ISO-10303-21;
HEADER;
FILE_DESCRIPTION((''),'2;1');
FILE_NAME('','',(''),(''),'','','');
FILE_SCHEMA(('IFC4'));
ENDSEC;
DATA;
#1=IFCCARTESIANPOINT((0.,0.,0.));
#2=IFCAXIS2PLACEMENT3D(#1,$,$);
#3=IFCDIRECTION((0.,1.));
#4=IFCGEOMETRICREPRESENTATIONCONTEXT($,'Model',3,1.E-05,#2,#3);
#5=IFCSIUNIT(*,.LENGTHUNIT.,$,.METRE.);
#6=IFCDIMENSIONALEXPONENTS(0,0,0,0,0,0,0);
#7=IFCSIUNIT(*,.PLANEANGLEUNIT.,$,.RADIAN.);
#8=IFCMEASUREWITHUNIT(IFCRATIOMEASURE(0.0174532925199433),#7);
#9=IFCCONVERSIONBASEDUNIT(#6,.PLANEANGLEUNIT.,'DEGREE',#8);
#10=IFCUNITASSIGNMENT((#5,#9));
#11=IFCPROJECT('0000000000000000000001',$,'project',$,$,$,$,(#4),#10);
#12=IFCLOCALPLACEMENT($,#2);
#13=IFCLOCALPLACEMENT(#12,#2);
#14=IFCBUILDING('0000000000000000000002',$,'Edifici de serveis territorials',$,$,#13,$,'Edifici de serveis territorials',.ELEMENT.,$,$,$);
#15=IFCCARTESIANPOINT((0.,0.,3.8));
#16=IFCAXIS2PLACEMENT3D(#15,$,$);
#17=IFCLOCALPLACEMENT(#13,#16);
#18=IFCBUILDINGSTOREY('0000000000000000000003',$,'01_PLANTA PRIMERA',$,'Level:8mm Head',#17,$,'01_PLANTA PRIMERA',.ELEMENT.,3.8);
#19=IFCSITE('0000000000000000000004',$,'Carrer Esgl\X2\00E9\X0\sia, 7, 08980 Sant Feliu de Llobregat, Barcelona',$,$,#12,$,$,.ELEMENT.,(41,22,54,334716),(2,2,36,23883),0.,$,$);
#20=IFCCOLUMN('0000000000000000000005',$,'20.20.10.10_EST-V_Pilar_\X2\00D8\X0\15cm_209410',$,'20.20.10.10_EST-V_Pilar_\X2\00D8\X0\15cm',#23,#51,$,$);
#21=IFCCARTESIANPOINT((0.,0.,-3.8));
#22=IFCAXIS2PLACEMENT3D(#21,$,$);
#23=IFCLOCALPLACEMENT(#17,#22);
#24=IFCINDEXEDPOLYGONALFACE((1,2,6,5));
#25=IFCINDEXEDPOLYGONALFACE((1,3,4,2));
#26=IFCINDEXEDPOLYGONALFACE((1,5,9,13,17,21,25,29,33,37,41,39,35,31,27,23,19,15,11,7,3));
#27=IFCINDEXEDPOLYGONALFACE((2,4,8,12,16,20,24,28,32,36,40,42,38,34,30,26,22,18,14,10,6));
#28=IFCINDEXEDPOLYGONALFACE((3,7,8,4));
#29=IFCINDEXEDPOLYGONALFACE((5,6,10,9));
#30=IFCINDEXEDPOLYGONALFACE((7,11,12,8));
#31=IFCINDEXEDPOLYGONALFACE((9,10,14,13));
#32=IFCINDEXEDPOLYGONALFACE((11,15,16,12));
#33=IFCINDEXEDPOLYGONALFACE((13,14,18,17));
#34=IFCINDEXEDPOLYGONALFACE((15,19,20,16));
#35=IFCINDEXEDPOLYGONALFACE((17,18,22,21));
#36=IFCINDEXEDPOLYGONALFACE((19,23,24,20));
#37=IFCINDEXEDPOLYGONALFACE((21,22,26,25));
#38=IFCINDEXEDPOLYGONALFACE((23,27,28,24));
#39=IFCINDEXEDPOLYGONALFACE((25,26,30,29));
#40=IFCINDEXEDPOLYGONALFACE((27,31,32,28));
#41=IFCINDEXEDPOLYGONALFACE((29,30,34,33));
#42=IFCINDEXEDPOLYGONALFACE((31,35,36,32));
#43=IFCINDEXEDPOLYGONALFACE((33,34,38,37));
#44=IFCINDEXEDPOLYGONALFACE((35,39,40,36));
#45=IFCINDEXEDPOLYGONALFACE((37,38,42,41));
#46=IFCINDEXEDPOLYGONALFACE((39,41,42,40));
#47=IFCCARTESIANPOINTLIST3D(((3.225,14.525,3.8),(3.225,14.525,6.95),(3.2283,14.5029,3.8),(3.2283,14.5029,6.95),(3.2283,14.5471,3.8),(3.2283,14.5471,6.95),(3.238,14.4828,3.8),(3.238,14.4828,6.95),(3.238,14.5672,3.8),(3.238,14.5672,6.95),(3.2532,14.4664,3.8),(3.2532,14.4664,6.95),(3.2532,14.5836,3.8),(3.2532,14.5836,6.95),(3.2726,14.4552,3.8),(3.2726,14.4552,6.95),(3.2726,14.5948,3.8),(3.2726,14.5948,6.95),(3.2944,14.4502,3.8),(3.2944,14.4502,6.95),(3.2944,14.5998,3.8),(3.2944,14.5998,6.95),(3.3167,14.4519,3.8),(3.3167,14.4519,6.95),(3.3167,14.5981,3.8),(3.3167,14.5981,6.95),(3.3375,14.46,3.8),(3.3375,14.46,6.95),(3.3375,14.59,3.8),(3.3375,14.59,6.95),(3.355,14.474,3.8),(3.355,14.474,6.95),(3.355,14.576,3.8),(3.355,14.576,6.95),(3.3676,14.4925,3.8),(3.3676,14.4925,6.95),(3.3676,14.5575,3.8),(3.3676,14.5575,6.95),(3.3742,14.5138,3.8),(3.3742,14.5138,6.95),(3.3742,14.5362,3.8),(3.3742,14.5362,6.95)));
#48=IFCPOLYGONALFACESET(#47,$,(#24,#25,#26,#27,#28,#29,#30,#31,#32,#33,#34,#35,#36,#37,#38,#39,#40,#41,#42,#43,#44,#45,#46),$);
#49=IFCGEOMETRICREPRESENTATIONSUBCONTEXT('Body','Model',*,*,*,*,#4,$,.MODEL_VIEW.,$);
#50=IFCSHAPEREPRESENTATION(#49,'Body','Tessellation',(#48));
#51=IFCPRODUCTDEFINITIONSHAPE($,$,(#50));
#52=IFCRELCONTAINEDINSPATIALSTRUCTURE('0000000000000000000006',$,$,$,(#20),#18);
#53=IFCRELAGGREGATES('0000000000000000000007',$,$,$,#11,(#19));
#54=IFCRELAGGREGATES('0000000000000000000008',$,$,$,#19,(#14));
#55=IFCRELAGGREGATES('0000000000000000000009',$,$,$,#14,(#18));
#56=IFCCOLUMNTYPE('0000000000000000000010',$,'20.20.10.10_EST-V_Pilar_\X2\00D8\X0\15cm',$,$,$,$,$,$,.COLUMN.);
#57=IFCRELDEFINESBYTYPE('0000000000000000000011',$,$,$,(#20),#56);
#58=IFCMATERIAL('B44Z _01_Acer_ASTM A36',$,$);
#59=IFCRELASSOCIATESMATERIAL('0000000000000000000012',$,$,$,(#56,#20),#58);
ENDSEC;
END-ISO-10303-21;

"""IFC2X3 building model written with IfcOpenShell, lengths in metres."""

from ifc_helpers import new_model, entity, si_unit, converted_unit, direction, frame, origin, origin_2d_with_axis, place, context, subcontext, project, spatial, circle, extrude, source, transform, mapped, material, type_object, type_shapes, element, save


model = new_model("IFC2X3")

# Units and contexts
model_context = context("Model", 3, precision=1e-05, world=origin(), true_north=direction((0.0, 1.0)))
body_context = subcontext(model_context, "Body", "Model", "MODEL_VIEW")
ifc_project = project(units=[si_unit("LENGTHUNIT", "METRE"), converted_unit("PLANEANGLEUNIT", "DEGREE", entity("IfcRatioMeasure", 0.0174532925199433), si_unit("PLANEANGLEUNIT", "RADIAN"), dimensions=[0, 0, 0, 0, 0, 0, 0])], contexts=[model_context])

# Site, building, storey
site_placement = place(None, origin())
site = spatial("IfcSite", under=ifc_project, at=site_placement, Name="Carrer Església, 7, 08980 Sant Feliu de Llobregat, Barcelona", CompositionType="ELEMENT", RefLatitude=(41, 22, 54, 334716), RefLongitude=(2, 2, 36, 23883), RefElevation=0.0)
building_placement = place(site_placement, origin())
building = spatial("IfcBuilding", under=site, at=building_placement, Name="Edifici de serveis territorials", LongName="Edifici de serveis territorials", CompositionType="ELEMENT")
storey_placement = place(building_placement, frame((0.0, 0.0, 3.8)))
storey = spatial("IfcBuildingStorey", under=building, at=storey_placement, Name="01_PLANTA PRIMERA", ObjectType="Level:8mm Head", LongName="01_PLANTA PRIMERA", CompositionType="ELEMENT", Elevation=3.8)

# Column
ifc_material_1 = material(Name="B44Z _01_Acer_ASTM A36")
column_type_1 = type_object("IfcColumnType", Name="20.20.10.10_EST-V_Pilar_Ø15cm", PredefinedType="COLUMN", material=ifc_material_1)
shared_shape_1 = source(origin(), body_context, "Body", "SweptSolid", [
    extrude(circle(Radius=0.075, at=origin_2d_with_axis()), frame((3.3, 14.525, 3.8), z_axis=(0.0, 0.0, 1.0), x_axis=(-1.0, 0.0, 0.0)), (0.0, 0.0, 1.0), 3.15),
])
type_shapes(column_type_1, [shared_shape_1])
column_1_placement = place(storey_placement, frame((0.0, 0.0, -3.8)))
element("IfcColumn", 1, at=column_1_placement, inside=storey, type_object=column_type_1, material=ifc_material_1, Name="20.20.10.10_EST-V_Pilar_Ø15cm_209410", ObjectType="20.20.10.10_EST-V_Pilar_Ø15cm", context=body_context, shape_type="MappedRepresentation", body=[
    mapped(shared_shape_1, transform((0.0, 0.0, 0.0), scale=1.0)),
])

save(model, "model.ifc")
